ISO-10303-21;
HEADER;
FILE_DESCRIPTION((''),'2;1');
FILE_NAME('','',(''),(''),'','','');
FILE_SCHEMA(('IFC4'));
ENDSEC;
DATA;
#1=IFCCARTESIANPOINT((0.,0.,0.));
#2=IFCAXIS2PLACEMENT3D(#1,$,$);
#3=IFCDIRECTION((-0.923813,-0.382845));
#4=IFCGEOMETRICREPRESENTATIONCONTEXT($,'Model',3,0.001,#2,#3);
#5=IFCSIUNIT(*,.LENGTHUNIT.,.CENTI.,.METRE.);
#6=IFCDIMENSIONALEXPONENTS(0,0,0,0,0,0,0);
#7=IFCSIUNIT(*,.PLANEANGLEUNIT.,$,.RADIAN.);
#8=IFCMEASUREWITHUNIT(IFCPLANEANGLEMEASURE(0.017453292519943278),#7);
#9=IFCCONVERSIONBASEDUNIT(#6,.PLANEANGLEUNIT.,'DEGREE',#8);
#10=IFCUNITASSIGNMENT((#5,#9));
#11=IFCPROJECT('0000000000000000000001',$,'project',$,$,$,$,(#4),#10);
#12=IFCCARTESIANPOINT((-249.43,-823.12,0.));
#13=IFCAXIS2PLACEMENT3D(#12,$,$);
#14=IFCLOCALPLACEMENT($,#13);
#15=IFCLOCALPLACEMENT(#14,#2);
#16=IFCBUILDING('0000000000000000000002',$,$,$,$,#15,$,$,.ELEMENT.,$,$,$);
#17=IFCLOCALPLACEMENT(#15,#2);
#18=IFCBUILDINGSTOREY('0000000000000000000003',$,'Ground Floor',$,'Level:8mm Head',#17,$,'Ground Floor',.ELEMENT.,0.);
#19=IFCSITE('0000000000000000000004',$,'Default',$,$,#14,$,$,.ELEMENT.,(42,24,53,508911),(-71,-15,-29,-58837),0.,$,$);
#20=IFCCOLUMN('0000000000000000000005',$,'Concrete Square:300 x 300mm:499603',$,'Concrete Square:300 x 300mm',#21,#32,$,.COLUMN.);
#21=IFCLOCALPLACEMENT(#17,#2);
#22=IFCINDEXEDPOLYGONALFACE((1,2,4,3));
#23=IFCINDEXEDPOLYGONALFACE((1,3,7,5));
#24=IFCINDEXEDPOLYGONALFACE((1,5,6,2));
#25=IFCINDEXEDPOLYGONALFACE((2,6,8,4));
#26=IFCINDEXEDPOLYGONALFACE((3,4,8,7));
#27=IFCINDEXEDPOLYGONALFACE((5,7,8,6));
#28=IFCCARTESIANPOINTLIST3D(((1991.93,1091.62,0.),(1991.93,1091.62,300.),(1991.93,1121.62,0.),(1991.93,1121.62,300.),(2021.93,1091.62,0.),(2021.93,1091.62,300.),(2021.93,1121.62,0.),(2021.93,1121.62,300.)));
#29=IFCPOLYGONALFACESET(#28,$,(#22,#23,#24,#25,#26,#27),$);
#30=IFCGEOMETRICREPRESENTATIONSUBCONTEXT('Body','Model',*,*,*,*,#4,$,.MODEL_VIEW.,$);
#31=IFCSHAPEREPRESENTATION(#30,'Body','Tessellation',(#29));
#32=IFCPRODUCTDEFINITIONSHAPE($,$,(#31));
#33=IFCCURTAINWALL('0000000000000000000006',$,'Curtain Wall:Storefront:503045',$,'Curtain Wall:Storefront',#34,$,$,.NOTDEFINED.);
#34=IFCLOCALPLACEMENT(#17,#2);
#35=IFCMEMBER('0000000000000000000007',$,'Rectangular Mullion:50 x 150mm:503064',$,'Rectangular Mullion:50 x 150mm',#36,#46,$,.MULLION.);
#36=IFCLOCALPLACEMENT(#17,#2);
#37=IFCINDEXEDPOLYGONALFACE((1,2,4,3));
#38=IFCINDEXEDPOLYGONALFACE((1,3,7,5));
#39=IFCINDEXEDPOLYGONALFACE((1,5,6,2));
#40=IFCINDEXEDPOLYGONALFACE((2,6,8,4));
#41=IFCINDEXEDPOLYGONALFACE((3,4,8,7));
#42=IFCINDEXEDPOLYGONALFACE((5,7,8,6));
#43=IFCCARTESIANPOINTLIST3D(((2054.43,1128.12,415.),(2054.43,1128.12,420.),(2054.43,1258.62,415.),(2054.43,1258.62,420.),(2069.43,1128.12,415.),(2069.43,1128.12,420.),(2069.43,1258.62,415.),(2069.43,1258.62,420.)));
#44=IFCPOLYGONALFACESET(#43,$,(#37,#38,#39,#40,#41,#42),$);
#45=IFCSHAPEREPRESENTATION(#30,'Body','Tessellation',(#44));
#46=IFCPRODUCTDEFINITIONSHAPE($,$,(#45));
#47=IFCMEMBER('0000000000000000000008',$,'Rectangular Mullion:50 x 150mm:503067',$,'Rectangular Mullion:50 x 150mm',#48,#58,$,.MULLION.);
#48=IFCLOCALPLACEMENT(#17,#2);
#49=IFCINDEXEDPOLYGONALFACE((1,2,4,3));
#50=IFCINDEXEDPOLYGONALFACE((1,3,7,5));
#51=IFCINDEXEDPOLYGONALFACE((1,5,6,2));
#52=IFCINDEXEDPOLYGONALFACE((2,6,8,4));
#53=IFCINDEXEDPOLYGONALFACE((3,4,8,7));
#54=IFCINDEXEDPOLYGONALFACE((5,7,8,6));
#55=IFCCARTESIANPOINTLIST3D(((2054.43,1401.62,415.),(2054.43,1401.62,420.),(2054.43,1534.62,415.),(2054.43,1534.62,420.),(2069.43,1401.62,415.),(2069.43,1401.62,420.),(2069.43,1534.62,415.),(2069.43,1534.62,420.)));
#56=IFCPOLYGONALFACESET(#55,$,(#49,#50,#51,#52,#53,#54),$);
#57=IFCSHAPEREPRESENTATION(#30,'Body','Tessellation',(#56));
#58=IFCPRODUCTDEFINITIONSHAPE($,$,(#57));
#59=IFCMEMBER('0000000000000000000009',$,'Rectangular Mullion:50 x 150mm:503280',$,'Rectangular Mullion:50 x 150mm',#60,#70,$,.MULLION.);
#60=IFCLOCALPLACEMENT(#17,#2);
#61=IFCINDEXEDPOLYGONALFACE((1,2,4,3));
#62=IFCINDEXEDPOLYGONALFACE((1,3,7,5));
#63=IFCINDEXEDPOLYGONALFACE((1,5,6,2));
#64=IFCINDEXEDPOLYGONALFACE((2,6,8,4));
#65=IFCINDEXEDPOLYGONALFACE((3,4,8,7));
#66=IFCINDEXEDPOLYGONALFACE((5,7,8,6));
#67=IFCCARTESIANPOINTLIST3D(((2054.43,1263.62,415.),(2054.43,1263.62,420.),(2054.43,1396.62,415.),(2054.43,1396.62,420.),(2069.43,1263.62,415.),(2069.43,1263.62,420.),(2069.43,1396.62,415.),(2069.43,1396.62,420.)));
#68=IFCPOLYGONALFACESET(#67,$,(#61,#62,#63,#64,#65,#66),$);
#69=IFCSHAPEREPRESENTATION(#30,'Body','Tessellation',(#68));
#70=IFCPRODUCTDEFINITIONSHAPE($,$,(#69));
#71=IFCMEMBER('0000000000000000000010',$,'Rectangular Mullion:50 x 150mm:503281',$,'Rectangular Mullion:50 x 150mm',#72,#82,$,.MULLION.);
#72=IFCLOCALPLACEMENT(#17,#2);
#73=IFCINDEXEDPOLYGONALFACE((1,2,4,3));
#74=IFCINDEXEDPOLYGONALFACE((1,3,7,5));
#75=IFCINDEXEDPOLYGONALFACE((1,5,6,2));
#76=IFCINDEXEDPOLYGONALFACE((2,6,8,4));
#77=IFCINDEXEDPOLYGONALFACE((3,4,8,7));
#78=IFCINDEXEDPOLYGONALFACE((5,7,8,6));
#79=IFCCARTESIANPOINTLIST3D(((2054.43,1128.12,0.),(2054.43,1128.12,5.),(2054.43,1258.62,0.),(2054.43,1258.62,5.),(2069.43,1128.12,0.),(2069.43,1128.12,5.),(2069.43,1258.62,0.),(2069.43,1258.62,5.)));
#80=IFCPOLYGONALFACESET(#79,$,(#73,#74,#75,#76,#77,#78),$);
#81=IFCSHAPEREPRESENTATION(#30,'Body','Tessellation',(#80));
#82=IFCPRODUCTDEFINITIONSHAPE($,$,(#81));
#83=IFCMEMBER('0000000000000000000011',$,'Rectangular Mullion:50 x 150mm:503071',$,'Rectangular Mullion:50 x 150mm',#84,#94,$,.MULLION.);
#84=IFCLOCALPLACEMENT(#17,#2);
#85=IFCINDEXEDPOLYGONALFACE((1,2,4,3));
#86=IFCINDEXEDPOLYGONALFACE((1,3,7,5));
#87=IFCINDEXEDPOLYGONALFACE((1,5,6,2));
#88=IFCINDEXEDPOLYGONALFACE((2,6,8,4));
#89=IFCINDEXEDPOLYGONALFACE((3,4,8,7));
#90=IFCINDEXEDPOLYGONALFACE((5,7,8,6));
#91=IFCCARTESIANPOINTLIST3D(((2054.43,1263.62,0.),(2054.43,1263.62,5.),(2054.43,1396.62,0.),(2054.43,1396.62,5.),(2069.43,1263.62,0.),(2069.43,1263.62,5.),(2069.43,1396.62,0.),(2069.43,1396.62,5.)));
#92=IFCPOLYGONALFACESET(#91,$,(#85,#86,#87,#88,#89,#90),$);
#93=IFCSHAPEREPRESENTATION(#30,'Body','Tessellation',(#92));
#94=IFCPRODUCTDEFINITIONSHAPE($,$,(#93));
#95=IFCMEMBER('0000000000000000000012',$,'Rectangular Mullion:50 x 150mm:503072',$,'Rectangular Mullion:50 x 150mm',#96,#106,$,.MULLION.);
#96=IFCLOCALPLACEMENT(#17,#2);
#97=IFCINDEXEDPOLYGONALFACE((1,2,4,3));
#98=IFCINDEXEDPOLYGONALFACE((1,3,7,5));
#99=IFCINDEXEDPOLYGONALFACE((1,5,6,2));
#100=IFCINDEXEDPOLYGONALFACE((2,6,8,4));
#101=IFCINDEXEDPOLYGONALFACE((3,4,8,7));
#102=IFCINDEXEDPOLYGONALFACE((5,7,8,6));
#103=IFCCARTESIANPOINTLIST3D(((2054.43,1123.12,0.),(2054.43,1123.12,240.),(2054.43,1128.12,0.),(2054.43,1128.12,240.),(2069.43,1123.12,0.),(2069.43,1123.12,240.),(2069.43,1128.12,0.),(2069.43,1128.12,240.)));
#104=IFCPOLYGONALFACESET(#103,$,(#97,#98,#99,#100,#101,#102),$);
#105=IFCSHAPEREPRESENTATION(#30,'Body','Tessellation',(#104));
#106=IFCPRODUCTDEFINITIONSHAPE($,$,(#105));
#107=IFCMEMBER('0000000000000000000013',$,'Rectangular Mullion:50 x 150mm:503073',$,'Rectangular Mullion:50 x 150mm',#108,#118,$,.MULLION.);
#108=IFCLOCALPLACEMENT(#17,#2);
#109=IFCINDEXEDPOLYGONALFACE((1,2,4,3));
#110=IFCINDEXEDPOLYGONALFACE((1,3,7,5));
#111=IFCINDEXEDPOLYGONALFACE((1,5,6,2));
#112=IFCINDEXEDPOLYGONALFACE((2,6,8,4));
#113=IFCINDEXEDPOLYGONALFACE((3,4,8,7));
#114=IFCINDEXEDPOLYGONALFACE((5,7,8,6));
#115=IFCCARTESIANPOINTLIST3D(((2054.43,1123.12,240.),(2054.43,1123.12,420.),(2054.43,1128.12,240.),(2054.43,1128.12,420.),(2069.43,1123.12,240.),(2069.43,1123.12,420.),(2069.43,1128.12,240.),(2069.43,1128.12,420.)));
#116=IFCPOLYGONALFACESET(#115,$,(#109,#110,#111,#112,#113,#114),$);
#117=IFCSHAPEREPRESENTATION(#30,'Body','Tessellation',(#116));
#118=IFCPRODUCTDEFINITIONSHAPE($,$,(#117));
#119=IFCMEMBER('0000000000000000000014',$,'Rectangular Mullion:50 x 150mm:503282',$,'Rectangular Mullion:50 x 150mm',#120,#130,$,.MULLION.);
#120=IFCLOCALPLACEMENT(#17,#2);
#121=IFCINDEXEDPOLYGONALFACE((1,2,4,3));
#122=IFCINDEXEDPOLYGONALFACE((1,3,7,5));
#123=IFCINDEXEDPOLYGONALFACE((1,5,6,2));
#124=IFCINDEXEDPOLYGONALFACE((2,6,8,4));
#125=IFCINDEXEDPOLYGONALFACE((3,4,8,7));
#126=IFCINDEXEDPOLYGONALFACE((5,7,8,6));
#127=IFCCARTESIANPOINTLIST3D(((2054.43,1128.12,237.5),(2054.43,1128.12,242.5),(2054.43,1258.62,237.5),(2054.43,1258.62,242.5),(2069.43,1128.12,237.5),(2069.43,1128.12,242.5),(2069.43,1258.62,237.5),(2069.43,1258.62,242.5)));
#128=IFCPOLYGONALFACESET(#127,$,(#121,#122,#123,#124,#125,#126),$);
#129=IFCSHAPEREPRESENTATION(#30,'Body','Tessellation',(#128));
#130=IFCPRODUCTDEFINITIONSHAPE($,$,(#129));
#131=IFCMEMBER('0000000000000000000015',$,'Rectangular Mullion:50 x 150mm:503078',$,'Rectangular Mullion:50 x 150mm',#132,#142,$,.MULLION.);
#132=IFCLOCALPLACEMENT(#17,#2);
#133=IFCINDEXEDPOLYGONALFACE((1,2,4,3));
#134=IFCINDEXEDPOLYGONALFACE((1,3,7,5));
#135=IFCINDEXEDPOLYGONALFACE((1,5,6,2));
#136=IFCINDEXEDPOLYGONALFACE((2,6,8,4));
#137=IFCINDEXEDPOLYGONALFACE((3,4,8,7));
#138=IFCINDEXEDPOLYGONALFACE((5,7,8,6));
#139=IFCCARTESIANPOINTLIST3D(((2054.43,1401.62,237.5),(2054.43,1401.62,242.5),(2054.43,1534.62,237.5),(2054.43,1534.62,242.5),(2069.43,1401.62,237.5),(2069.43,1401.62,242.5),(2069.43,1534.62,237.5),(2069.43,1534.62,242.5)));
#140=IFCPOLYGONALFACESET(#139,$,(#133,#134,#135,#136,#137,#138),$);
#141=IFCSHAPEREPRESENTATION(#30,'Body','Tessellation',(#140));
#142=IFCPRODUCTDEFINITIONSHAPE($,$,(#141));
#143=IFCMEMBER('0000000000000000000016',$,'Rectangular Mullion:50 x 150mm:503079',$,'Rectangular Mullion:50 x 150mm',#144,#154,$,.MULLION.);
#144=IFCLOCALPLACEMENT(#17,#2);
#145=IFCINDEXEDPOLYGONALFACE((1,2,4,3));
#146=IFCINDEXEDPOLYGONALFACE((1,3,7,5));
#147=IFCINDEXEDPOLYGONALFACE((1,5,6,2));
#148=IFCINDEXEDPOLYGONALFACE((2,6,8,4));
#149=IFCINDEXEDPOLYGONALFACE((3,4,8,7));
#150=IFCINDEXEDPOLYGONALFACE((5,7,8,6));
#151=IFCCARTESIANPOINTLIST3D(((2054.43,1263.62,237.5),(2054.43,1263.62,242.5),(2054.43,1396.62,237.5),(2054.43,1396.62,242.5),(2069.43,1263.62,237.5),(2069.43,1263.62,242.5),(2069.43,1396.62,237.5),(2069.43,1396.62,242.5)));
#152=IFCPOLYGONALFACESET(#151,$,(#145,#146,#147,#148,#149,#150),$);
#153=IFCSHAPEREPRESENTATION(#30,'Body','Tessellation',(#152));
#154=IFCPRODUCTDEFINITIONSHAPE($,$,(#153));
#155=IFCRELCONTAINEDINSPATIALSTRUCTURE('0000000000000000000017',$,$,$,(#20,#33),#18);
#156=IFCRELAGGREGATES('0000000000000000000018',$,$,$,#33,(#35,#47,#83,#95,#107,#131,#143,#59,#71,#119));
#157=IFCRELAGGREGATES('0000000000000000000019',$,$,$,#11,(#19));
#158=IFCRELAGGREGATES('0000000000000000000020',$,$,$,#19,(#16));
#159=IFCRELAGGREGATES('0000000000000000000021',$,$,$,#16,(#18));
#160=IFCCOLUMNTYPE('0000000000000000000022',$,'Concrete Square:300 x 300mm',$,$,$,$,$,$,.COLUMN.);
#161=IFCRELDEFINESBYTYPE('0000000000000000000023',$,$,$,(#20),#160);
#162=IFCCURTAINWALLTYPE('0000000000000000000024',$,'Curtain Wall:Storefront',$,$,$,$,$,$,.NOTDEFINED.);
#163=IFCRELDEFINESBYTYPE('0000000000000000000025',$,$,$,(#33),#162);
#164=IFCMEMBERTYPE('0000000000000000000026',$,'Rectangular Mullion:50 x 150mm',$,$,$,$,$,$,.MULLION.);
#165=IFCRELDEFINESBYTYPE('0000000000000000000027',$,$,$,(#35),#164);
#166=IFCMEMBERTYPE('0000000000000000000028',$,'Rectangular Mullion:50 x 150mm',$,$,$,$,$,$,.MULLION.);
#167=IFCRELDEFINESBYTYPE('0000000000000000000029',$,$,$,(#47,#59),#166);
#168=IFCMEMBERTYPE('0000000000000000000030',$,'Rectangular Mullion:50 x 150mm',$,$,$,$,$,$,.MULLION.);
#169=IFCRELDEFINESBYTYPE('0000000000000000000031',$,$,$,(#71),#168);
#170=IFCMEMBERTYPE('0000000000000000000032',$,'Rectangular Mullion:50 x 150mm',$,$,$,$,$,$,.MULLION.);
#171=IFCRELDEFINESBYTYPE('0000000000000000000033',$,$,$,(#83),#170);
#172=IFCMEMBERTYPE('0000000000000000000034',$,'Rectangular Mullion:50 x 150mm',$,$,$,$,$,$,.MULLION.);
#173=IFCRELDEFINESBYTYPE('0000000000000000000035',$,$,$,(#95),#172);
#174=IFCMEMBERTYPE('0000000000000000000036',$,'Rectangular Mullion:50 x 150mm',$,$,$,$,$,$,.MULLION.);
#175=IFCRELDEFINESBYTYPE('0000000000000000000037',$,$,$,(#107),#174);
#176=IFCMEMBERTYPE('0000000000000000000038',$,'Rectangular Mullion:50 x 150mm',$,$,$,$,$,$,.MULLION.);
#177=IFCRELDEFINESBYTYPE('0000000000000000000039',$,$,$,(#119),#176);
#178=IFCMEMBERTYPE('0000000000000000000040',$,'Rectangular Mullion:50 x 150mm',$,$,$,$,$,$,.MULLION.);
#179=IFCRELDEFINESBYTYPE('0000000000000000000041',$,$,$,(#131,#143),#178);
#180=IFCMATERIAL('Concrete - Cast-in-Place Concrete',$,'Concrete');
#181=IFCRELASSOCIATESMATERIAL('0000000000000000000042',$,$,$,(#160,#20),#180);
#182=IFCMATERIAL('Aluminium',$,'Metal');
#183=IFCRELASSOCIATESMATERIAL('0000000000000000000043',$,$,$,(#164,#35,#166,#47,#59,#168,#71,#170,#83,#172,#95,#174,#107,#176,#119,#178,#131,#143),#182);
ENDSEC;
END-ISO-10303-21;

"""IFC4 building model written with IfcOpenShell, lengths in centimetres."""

from ifc_helpers import new_model, entity, si_unit, converted_unit, direction, frame, origin, place, context, subcontext, project, spatial, indexed_curve, outline, extrude, source, transform, mapped, material, type_object, type_shapes, element, aggregate, save


model = new_model("IFC4")

# Units and contexts
model_context = context("Model", 3, precision=0.001, world=origin(), true_north=direction((-0.923813, -0.382845)))
body_context = subcontext(model_context, "Body", "Model", "MODEL_VIEW")
ifc_project = project(units=[si_unit("LENGTHUNIT", "METRE", prefix="CENTI"), converted_unit("PLANEANGLEUNIT", "DEGREE", entity("IfcPlaneAngleMeasure", 0.017453292519943278), si_unit("PLANEANGLEUNIT", "RADIAN"), dimensions=[0, 0, 0, 0, 0, 0, 0])], contexts=[model_context])

# Site, building, storey
site_placement = place(None, frame((-249.43, -823.12, 0.0)))
site = spatial("IfcSite", under=ifc_project, at=site_placement, Name="Default", CompositionType="ELEMENT", RefLatitude=(42, 24, 53, 508911), RefLongitude=(-71, -15, -29, -58837), RefElevation=0.0)
building_placement = place(site_placement, origin())
building = spatial("IfcBuilding", under=site, at=building_placement, CompositionType="ELEMENT")
storey_placement = place(building_placement, origin())
storey = spatial("IfcBuildingStorey", under=building, at=storey_placement, Name="Ground Floor", ObjectType="Level:8mm Head", LongName="Ground Floor", CompositionType="ELEMENT", Elevation=0.0)

# Column
ifc_material_1 = material(Name="Concrete - Cast-in-Place Concrete", Category="Concrete")
column_type = type_object("IfcColumnType", Name="Concrete Square:300 x 300mm", PredefinedType="COLUMN", material=ifc_material_1)
shared_shape_1 = source(origin(), body_context, "Body", "SweptSolid", [
    extrude(outline(indexed_curve([(-15.0, -15.0), (15.0, -15.0), (15.0, 15.0), (-15.0, 15.0), (-15.0, -15.0)], self_intersect=False)), frame((0.0, 0.0, 0.0), z_axis=(0.0, 0.0, 1.0), x_axis=(-1.0, 0.0, 0.0)), (0.0, 0.0, 1.0), 300.0),
])
type_shapes(column_type, [shared_shape_1])
column_placement = place(storey_placement, frame((2006.93, 1106.62, 0.0)))
element("IfcColumn", 1, at=column_placement, inside=storey, type_object=column_type, material=ifc_material_1, Name="Concrete Square:300 x 300mm:499603", ObjectType="Concrete Square:300 x 300mm", PredefinedType="COLUMN", context=body_context, shape_type="MappedRepresentation", body=[
    mapped(shared_shape_1, transform((0.0, 0.0, 0.0), scale=1.0)),
])

# Curtain wall, members
curtain_wall_type = type_object("IfcCurtainWallType", Name="Curtain Wall:Storefront", PredefinedType="NOTDEFINED")
curtain_wall_placement = place(storey_placement, origin())
curtain_wall = element("IfcCurtainWall", 2, at=curtain_wall_placement, inside=storey, type_object=curtain_wall_type, Name="Curtain Wall:Storefront:503045", ObjectType="Curtain Wall:Storefront", PredefinedType="NOTDEFINED")
ifc_material_2 = material(Name="Aluminium", Category="Metal")
member_type_1 = type_object("IfcMemberType", Name="Rectangular Mullion:50 x 150mm", PredefinedType="MULLION", material=ifc_material_2)
shared_shape_2 = source(origin(), body_context, "Body", "SweptSolid", [
    extrude(outline(indexed_curve([(-2.5, -7.5), (2.5, -7.5), (2.5, 7.5), (-2.5, 7.5), (-2.5, -7.5)], self_intersect=False)), frame((-2.5, 0.0, -130.5), z_axis=(0.0, 0.0, 1.0), x_axis=(-1.0, 0.0, 0.0)), (0.0, 0.0, 1.0), 130.5),
])
type_shapes(member_type_1, [shared_shape_2])
member_1_placement = place(curtain_wall_placement, frame((2061.93, 1128.12, 420.0), z_axis=(0.0, -1.0, 0.0), x_axis=(0.0, 0.0, 1.0)))
member_1 = element("IfcMember", 3, at=member_1_placement, type_object=member_type_1, material=ifc_material_2, Name="Rectangular Mullion:50 x 150mm:503064", ObjectType="Rectangular Mullion:50 x 150mm", PredefinedType="MULLION", context=body_context, shape_type="MappedRepresentation", body=[
    mapped(shared_shape_2, transform((0.0, 0.0, 0.0), scale=1.0)),
])
member_type_2 = type_object("IfcMemberType", Name="Rectangular Mullion:50 x 150mm", PredefinedType="MULLION", material=ifc_material_2)
shared_shape_3 = source(origin(), body_context, "Body", "SweptSolid", [
    extrude(outline(indexed_curve([(-2.5, -7.5), (2.5, -7.5), (2.5, 7.5), (-2.5, 7.5), (-2.5, -7.5)], self_intersect=False)), frame((-2.5, 0.0, -133.0), z_axis=(0.0, 0.0, 1.0), x_axis=(-1.0, 0.0, 0.0)), (0.0, 0.0, 1.0), 133.0),
])
type_shapes(member_type_2, [shared_shape_3])
member_2_placement = place(curtain_wall_placement, frame((2061.93, 1401.62, 420.0), z_axis=(0.0, -1.0, 0.0), x_axis=(0.0, 0.0, 1.0)))
member_2 = element("IfcMember", 4, at=member_2_placement, type_object=member_type_2, material=ifc_material_2, Name="Rectangular Mullion:50 x 150mm:503067", ObjectType="Rectangular Mullion:50 x 150mm", PredefinedType="MULLION", context=body_context, shape_type="MappedRepresentation", body=[
    mapped(shared_shape_3, transform((0.0, 0.0, 0.0), scale=1.0)),
])
member_3_placement = place(curtain_wall_placement, frame((2061.93, 1263.62, 420.0), z_axis=(0.0, -1.0, 0.0), x_axis=(0.0, 0.0, 1.0)))
member_3 = element("IfcMember", 5, at=member_3_placement, type_object=member_type_2, material=ifc_material_2, Name="Rectangular Mullion:50 x 150mm:503280", ObjectType="Rectangular Mullion:50 x 150mm", PredefinedType="MULLION", context=body_context, shape_type="MappedRepresentation", body=[
    mapped(shared_shape_3, transform((0.0, 0.0, 0.0), scale=1.0)),
])
member_type_3 = type_object("IfcMemberType", Name="Rectangular Mullion:50 x 150mm", PredefinedType="MULLION", material=ifc_material_2)
shared_shape_4 = source(origin(), body_context, "Body", "SweptSolid", [
    extrude(outline(indexed_curve([(-2.5, -7.5), (2.5, -7.5), (2.5, 7.5), (-2.5, 7.5), (-2.5, -7.5)], self_intersect=False)), frame((-2.5, 0.0, -130.5), z_axis=(0.0, 0.0, 1.0), x_axis=(-1.0, 0.0, 0.0)), (0.0, 0.0, 1.0), 130.5),
])
type_shapes(member_type_3, [shared_shape_4])
member_4_placement = place(curtain_wall_placement, frame((2061.93, 1258.62, 0.0), z_axis=(0.0, 1.0, 0.0), x_axis=(0.0, 0.0, -1.0)))
member_4 = element("IfcMember", 6, at=member_4_placement, type_object=member_type_3, material=ifc_material_2, Name="Rectangular Mullion:50 x 150mm:503281", ObjectType="Rectangular Mullion:50 x 150mm", PredefinedType="MULLION", context=body_context, shape_type="MappedRepresentation", body=[
    mapped(shared_shape_4, transform((0.0, 0.0, 0.0), scale=1.0)),
])
member_type_4 = type_object("IfcMemberType", Name="Rectangular Mullion:50 x 150mm", PredefinedType="MULLION", material=ifc_material_2)
shared_shape_5 = source(origin(), body_context, "Body", "SweptSolid", [
    extrude(outline(indexed_curve([(-2.5, -7.5), (2.5, -7.5), (2.5, 7.5), (-2.5, 7.5), (-2.5, -7.5)], self_intersect=False)), frame((-2.5, 0.0, -133.0), z_axis=(0.0, 0.0, 1.0), x_axis=(-1.0, 0.0, 0.0)), (0.0, 0.0, 1.0), 133.0),
])
type_shapes(member_type_4, [shared_shape_5])
member_5_placement = place(curtain_wall_placement, frame((2061.93, 1396.62, 0.0), z_axis=(0.0, 1.0, 0.0), x_axis=(0.0, 0.0, -1.0)))
member_5 = element("IfcMember", 7, at=member_5_placement, type_object=member_type_4, material=ifc_material_2, Name="Rectangular Mullion:50 x 150mm:503071", ObjectType="Rectangular Mullion:50 x 150mm", PredefinedType="MULLION", context=body_context, shape_type="MappedRepresentation", body=[
    mapped(shared_shape_5, transform((0.0, 0.0, 0.0), scale=1.0)),
])
member_type_5 = type_object("IfcMemberType", Name="Rectangular Mullion:50 x 150mm", PredefinedType="MULLION", material=ifc_material_2)
shared_shape_6 = source(origin(), body_context, "Body", "SweptSolid", [
    extrude(outline(indexed_curve([(-2.5, -7.5), (2.5, -7.5), (2.5, 7.5), (-2.5, 7.5), (-2.5, -7.5)], self_intersect=False)), frame((-2.5, 0.0, -240.0), z_axis=(0.0, 0.0, 1.0), x_axis=(-1.0, 0.0, 0.0)), (0.0, 0.0, 1.0), 240.0),
])
type_shapes(member_type_5, [shared_shape_6])
member_6_placement = place(curtain_wall_placement, frame((2061.93, 1123.12, 0.0), z_axis=(0.0, 0.0, -1.0), x_axis=(0.0, -1.0, 0.0)))
member_6 = element("IfcMember", 8, at=member_6_placement, type_object=member_type_5, material=ifc_material_2, Name="Rectangular Mullion:50 x 150mm:503072", ObjectType="Rectangular Mullion:50 x 150mm", PredefinedType="MULLION", context=body_context, shape_type="MappedRepresentation", body=[
    mapped(shared_shape_6, transform((0.0, 0.0, 0.0), scale=1.0)),
])
member_type_6 = type_object("IfcMemberType", Name="Rectangular Mullion:50 x 150mm", PredefinedType="MULLION", material=ifc_material_2)
shared_shape_7 = source(origin(), body_context, "Body", "SweptSolid", [
    extrude(outline(indexed_curve([(-2.5, -7.5), (2.5, -7.5), (2.5, 7.5), (-2.5, 7.5), (-2.5, -7.5)], self_intersect=False)), frame((-2.5, 0.0, -180.0), z_axis=(0.0, 0.0, 1.0), x_axis=(-1.0, 0.0, 0.0)), (0.0, 0.0, 1.0), 180.0),
])
type_shapes(member_type_6, [shared_shape_7])
member_7_placement = place(curtain_wall_placement, frame((2061.93, 1123.12, 240.0), z_axis=(0.0, 0.0, -1.0), x_axis=(0.0, -1.0, 0.0)))
member_7 = element("IfcMember", 9, at=member_7_placement, type_object=member_type_6, material=ifc_material_2, Name="Rectangular Mullion:50 x 150mm:503073", ObjectType="Rectangular Mullion:50 x 150mm", PredefinedType="MULLION", context=body_context, shape_type="MappedRepresentation", body=[
    mapped(shared_shape_7, transform((0.0, 0.0, 0.0), scale=1.0)),
])
member_type_7 = type_object("IfcMemberType", Name="Rectangular Mullion:50 x 150mm", PredefinedType="MULLION", material=ifc_material_2)
shared_shape_8 = source(origin(), body_context, "Body", "SweptSolid", [
    extrude(outline(indexed_curve([(-2.5, -7.5), (2.5, -7.5), (2.5, 7.5), (-2.5, 7.5), (-2.5, -7.5)], self_intersect=False)), frame((0.0, 0.0, -130.5), z_axis=(0.0, 0.0, 1.0), x_axis=(-1.0, 0.0, 0.0)), (0.0, 0.0, 1.0), 130.5),
])
type_shapes(member_type_7, [shared_shape_8])
member_8_placement = place(curtain_wall_placement, frame((2061.93, 1128.12, 240.0), z_axis=(0.0, -1.0, 0.0), x_axis=(0.0, 0.0, 1.0)))
member_8 = element("IfcMember", 10, at=member_8_placement, type_object=member_type_7, material=ifc_material_2, Name="Rectangular Mullion:50 x 150mm:503282", ObjectType="Rectangular Mullion:50 x 150mm", PredefinedType="MULLION", context=body_context, shape_type="MappedRepresentation", body=[
    mapped(shared_shape_8, transform((0.0, 0.0, 0.0), scale=1.0)),
])
member_type_8 = type_object("IfcMemberType", Name="Rectangular Mullion:50 x 150mm", PredefinedType="MULLION", material=ifc_material_2)
shared_shape_9 = source(origin(), body_context, "Body", "SweptSolid", [
    extrude(outline(indexed_curve([(-2.5, -7.5), (2.5, -7.5), (2.5, 7.5), (-2.5, 7.5), (-2.5, -7.5)], self_intersect=False)), frame((0.0, 0.0, -133.0), z_axis=(0.0, 0.0, 1.0), x_axis=(-1.0, 0.0, 0.0)), (0.0, 0.0, 1.0), 133.0),
])
type_shapes(member_type_8, [shared_shape_9])
member_9_placement = place(curtain_wall_placement, frame((2061.93, 1401.62, 240.0), z_axis=(0.0, -1.0, 0.0), x_axis=(0.0, 0.0, 1.0)))
member_9 = element("IfcMember", 11, at=member_9_placement, type_object=member_type_8, material=ifc_material_2, Name="Rectangular Mullion:50 x 150mm:503078", ObjectType="Rectangular Mullion:50 x 150mm", PredefinedType="MULLION", context=body_context, shape_type="MappedRepresentation", body=[
    mapped(shared_shape_9, transform((0.0, 0.0, 0.0), scale=1.0)),
])
member_10_placement = place(curtain_wall_placement, frame((2061.93, 1263.62, 240.0), z_axis=(0.0, -1.0, 0.0), x_axis=(0.0, 0.0, 1.0)))
member_10 = element("IfcMember", 12, at=member_10_placement, type_object=member_type_8, material=ifc_material_2, Name="Rectangular Mullion:50 x 150mm:503079", ObjectType="Rectangular Mullion:50 x 150mm", PredefinedType="MULLION", context=body_context, shape_type="MappedRepresentation", body=[
    mapped(shared_shape_9, transform((0.0, 0.0, 0.0), scale=1.0)),
])

aggregate(curtain_wall, [member_1, member_2, member_5, member_6, member_7, member_9, member_10, member_3, member_4, member_8])

save(model, "model.ifc")
